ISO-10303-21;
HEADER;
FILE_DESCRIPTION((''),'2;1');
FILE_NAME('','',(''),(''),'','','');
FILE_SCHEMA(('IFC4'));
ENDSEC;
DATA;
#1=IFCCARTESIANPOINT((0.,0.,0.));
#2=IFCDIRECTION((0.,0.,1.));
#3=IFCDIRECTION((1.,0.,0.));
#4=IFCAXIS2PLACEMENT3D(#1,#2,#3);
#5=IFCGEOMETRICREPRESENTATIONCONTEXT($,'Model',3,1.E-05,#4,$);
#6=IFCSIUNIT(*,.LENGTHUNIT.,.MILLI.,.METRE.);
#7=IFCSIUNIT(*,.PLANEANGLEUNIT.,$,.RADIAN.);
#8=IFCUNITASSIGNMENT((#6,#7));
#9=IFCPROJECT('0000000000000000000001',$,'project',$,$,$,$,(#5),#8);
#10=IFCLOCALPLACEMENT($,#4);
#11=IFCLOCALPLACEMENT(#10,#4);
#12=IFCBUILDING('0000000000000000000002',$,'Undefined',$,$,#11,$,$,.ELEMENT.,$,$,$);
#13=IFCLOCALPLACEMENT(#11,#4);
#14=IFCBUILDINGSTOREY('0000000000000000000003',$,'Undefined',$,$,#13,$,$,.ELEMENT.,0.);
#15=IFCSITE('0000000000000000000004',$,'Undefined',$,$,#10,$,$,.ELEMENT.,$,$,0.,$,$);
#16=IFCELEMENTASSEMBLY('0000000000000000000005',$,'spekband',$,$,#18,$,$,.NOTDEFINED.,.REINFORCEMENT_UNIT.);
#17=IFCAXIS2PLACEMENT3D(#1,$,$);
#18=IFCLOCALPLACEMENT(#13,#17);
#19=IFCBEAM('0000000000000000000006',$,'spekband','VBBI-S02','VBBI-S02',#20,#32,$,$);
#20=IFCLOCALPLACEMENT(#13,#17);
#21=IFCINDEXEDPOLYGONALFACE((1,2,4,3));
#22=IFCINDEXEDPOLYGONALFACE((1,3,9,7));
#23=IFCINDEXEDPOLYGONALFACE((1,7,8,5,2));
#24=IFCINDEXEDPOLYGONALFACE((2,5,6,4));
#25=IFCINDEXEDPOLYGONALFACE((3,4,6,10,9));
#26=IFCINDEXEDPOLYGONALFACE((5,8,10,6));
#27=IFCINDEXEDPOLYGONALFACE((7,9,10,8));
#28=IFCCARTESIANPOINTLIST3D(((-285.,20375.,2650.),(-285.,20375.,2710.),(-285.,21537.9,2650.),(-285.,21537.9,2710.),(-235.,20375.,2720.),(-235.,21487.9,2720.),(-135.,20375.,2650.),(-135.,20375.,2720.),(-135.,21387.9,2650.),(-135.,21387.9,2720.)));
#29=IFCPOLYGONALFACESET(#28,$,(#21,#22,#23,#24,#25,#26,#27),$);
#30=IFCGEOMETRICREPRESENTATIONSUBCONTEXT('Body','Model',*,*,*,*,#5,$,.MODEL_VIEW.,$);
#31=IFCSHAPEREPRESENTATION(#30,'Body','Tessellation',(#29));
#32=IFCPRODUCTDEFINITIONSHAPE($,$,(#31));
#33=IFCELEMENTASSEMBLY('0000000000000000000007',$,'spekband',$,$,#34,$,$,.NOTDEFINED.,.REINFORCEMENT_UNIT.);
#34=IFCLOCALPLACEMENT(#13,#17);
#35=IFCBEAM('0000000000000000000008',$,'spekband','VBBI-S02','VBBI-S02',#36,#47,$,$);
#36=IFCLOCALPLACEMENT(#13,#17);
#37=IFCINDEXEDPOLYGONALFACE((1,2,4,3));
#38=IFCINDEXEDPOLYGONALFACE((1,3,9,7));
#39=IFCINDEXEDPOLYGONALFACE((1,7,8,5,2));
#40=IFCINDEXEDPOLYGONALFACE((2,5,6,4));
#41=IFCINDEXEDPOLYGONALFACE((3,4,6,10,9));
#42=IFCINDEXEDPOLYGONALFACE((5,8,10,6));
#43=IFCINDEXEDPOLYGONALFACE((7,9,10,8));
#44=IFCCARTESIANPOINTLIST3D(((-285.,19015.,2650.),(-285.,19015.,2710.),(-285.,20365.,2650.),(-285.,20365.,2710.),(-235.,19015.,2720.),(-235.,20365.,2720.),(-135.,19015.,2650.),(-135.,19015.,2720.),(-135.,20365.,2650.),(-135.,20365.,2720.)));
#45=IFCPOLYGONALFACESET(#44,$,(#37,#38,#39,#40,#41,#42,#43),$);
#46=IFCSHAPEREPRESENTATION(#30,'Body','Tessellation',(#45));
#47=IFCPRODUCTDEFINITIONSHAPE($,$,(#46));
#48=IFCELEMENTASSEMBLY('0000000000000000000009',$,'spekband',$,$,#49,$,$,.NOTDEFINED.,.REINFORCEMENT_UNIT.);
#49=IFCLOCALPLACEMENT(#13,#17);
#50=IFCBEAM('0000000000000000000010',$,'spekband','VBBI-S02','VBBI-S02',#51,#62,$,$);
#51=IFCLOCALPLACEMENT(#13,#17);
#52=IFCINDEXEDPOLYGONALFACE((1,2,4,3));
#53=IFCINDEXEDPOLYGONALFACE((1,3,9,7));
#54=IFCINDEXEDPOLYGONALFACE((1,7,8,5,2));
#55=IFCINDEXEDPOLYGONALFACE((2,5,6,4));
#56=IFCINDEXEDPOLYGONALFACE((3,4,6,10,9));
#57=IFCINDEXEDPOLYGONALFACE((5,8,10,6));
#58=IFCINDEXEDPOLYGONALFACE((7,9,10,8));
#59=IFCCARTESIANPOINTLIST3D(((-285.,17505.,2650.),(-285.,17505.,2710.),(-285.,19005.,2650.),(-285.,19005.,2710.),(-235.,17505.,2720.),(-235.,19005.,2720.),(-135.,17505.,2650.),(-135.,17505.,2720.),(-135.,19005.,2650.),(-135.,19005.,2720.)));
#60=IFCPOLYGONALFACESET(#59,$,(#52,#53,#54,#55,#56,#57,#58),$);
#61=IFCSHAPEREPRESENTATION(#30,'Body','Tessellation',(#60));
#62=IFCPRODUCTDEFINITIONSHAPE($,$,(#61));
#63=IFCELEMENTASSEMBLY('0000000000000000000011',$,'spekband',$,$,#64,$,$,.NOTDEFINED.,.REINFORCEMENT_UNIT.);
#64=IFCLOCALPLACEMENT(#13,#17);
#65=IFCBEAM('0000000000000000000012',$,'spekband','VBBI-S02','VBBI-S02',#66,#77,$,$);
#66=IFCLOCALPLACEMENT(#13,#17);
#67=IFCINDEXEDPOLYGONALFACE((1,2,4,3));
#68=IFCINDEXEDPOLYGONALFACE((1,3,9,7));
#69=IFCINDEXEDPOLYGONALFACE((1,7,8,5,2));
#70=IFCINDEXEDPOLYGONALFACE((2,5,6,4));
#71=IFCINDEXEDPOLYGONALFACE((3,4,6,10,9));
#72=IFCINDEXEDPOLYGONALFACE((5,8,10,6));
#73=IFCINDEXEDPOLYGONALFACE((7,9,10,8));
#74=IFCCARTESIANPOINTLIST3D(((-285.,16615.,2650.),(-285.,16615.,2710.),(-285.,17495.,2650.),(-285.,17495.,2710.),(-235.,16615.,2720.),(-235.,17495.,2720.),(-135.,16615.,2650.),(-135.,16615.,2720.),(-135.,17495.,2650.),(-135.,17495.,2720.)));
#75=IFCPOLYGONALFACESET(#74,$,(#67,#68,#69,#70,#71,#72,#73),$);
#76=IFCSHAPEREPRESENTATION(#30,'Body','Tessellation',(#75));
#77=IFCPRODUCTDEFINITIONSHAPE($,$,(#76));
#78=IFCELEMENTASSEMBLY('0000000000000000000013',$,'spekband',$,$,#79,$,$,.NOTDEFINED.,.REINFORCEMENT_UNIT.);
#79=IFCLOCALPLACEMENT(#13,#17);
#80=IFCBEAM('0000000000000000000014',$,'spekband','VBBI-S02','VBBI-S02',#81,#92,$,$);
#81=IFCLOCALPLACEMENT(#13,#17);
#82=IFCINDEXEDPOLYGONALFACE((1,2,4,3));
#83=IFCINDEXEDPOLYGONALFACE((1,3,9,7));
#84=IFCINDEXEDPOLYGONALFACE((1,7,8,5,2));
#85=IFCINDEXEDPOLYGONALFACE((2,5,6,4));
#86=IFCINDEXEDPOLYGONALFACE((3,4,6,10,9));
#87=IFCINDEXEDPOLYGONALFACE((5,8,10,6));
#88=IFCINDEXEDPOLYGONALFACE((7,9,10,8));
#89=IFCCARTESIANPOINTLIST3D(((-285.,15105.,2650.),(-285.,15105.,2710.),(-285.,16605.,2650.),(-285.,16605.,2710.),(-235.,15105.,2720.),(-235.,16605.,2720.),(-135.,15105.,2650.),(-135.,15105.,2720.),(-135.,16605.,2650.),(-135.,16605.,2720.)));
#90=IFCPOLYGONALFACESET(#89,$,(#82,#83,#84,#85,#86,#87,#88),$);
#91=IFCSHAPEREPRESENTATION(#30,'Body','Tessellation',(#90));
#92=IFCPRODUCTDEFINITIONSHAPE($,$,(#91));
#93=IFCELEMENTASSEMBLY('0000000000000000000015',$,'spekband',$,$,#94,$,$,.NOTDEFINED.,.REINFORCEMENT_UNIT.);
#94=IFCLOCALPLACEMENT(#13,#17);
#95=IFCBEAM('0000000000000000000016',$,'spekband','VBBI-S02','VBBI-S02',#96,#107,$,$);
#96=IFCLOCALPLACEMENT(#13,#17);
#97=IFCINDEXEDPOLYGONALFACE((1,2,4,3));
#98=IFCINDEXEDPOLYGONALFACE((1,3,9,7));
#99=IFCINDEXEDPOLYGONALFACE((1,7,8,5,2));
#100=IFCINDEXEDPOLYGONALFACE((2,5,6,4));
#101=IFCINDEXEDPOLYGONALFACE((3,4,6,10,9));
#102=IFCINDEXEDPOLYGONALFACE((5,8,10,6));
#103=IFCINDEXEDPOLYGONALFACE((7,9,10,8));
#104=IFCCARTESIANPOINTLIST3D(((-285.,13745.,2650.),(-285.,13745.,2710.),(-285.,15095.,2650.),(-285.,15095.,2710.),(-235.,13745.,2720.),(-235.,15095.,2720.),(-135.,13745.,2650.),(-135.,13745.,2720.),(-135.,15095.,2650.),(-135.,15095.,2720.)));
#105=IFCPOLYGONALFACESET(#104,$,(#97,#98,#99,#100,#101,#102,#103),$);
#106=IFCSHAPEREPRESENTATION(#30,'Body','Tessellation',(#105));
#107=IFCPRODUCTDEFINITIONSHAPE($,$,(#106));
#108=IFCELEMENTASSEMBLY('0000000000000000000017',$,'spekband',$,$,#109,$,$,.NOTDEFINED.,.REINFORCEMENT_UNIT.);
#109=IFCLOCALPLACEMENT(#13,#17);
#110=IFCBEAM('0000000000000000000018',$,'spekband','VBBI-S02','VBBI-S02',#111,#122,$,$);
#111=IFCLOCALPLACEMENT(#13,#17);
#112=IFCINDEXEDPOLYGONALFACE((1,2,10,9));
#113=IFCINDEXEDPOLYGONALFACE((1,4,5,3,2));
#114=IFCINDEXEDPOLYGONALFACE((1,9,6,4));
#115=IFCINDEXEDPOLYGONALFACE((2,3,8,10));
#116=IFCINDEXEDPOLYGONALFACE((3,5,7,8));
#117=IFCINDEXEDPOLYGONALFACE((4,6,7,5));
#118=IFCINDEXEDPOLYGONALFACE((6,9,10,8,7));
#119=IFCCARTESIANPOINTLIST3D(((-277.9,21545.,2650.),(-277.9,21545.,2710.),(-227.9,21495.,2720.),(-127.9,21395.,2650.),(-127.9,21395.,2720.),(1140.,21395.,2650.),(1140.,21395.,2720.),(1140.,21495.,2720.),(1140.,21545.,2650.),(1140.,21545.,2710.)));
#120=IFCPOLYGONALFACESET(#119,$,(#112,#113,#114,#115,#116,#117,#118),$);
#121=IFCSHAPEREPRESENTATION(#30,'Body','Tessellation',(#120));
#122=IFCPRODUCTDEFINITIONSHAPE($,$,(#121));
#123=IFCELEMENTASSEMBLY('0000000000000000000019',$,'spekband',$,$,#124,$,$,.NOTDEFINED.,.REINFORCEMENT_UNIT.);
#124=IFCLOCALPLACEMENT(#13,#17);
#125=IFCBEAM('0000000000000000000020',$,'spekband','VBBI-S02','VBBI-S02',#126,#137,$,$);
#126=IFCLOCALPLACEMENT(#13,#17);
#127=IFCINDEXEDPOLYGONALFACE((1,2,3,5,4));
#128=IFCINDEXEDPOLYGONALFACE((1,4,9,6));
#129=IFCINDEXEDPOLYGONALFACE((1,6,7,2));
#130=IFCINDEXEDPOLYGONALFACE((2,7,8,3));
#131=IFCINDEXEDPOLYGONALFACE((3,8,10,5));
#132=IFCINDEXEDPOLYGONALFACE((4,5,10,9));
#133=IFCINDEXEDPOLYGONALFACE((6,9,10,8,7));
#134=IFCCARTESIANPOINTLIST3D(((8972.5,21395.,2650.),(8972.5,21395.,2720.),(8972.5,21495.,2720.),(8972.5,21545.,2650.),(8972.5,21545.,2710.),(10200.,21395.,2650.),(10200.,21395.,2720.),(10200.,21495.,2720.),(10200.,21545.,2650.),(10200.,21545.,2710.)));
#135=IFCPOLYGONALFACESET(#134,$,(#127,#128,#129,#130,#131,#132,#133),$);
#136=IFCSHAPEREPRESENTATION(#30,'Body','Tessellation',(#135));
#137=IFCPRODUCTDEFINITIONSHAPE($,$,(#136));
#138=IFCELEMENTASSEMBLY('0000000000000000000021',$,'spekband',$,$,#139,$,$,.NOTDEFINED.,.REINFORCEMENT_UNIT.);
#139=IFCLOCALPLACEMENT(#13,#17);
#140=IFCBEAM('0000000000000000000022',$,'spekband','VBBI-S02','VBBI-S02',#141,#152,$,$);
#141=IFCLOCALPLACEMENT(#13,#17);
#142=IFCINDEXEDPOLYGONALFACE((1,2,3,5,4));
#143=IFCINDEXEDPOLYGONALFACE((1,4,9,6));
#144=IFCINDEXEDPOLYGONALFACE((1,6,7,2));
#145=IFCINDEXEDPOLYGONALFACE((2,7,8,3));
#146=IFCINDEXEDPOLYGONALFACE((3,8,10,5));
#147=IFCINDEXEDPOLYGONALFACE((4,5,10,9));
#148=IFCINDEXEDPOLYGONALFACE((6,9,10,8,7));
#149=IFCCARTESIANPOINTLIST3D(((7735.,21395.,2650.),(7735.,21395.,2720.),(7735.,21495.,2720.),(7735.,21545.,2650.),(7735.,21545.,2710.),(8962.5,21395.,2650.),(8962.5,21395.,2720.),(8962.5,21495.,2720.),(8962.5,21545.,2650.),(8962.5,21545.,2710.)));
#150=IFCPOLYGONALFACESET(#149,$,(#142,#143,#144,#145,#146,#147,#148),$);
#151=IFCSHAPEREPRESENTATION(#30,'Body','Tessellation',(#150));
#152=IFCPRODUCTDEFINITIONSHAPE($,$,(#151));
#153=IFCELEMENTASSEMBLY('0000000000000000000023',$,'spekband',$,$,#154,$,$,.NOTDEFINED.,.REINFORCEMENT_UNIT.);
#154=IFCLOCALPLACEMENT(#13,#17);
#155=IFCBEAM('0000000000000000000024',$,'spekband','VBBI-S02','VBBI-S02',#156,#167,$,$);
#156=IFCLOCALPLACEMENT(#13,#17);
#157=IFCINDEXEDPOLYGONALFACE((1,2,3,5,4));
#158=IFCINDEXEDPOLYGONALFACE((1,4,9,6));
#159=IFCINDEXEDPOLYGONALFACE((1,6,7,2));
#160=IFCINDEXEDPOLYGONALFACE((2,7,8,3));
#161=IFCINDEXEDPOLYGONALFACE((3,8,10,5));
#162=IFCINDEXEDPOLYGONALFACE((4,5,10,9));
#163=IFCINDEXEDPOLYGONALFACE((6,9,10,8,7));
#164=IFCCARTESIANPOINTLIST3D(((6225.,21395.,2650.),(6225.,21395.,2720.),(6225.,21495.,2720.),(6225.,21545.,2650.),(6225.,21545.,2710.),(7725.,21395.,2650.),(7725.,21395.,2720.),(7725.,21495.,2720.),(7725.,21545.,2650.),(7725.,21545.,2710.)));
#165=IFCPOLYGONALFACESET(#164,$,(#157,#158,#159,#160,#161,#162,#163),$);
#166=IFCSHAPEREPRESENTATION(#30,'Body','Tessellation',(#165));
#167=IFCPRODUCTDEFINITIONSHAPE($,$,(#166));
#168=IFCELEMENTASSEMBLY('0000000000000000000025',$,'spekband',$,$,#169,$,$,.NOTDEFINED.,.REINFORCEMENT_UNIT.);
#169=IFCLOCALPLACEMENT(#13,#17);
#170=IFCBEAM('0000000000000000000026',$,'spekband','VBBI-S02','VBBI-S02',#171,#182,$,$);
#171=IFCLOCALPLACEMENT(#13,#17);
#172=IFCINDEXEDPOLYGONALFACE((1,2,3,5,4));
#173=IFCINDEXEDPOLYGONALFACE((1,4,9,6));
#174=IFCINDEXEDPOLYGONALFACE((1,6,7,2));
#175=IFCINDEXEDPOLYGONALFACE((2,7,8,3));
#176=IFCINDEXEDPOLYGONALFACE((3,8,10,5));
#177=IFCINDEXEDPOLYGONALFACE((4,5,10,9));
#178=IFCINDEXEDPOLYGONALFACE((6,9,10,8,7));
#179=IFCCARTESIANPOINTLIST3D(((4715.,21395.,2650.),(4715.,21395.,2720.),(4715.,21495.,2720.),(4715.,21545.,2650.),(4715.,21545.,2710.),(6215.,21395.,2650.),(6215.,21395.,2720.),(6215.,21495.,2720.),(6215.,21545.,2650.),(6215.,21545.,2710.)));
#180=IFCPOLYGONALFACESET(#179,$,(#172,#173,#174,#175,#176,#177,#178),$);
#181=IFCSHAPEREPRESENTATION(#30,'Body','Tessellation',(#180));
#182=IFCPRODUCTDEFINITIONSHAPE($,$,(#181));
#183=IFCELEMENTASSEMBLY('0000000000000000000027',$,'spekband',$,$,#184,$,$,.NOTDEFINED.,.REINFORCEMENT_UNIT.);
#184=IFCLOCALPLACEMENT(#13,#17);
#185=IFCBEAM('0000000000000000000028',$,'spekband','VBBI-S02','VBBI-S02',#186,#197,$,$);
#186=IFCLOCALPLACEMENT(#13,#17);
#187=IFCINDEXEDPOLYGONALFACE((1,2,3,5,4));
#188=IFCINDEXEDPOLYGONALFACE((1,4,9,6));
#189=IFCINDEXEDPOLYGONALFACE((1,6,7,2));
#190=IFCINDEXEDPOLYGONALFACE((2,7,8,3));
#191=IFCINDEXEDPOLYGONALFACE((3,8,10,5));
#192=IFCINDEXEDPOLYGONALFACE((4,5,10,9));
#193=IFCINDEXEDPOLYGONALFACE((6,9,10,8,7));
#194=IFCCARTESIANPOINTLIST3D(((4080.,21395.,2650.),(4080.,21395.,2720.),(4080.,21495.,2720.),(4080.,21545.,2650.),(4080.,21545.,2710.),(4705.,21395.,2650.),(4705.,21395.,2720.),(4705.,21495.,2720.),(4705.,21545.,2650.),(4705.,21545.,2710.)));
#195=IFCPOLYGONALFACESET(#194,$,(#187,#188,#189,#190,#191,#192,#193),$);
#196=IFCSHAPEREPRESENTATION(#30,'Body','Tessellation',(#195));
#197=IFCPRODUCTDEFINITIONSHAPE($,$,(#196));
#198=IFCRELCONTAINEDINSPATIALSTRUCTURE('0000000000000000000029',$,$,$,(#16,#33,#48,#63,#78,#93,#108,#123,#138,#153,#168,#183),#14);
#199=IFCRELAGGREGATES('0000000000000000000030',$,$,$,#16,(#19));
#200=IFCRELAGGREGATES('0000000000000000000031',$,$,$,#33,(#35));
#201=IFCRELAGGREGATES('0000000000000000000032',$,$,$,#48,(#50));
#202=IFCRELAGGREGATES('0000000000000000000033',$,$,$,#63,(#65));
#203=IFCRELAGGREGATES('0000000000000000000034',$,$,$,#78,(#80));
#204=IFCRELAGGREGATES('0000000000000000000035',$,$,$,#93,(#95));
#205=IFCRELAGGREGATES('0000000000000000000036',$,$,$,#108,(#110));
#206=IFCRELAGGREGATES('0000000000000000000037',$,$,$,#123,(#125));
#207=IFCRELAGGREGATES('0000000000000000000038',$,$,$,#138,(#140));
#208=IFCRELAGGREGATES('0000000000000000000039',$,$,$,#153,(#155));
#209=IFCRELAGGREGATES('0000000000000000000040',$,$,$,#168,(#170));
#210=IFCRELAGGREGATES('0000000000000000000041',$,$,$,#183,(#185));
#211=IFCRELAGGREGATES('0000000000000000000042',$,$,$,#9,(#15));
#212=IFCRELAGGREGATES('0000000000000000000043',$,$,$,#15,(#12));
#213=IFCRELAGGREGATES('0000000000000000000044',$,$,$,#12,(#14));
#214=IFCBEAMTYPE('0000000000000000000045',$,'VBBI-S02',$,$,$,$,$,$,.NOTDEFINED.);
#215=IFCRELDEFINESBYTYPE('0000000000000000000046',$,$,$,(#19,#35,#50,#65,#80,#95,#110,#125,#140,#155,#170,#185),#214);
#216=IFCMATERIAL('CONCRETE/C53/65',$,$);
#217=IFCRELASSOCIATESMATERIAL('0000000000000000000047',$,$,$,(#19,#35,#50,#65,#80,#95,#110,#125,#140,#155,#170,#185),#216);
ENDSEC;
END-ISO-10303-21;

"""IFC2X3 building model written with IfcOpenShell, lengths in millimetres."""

from ifc_helpers import new_model, si_unit, frame, origin_with_axes, place, context, subcontext, project, spatial, polyline, outline, extrude, clip, halfspace, material, type_object, element, aggregate, save


model = new_model("IFC2X3")

# Units and contexts
model_context = context("Model", 3, precision=1e-05, world=origin_with_axes())
body_context = subcontext(model_context, "Body", "Model", "MODEL_VIEW")
ifc_project = project(units=[si_unit("LENGTHUNIT", "METRE", prefix="MILLI"), si_unit("PLANEANGLEUNIT", "RADIAN")], contexts=[model_context])

# Site, building, storey
site_placement = place(None, origin_with_axes())
site = spatial("IfcSite", under=ifc_project, at=site_placement, Name="Undefined", CompositionType="ELEMENT", RefElevation=0.0)
building_placement = place(site_placement, origin_with_axes())
building = spatial("IfcBuilding", under=site, at=building_placement, Name="Undefined", CompositionType="ELEMENT")
storey_placement = place(building_placement, origin_with_axes())
storey = spatial("IfcBuildingStorey", under=building, at=storey_placement, Name="Undefined", CompositionType="ELEMENT", Elevation=0.0)

# Element assemblies, beams
assembly_1_placement = place(storey_placement, origin_with_axes())
assembly_1 = element("IfcElementAssembly", 1, at=assembly_1_placement, inside=storey, Name="spekband", AssemblyPlace="NOTDEFINED", PredefinedType="REINFORCEMENT_UNIT")
ifc_material_1 = material(Name="CONCRETE/C53/65")
beam_type = type_object("IfcBeamType", Name="VBBI-S02", PredefinedType="NOTDEFINED")
beam_1_placement = place(assembly_1_placement, frame((-210.0, 21545.0, 2685.0), z_axis=(-1.0, 0.0, 0.0), x_axis=(0.0, -1.0, 0.0)))
beam_1 = element("IfcBeam", 2, at=beam_1_placement, type_object=beam_type, material=ifc_material_1, Name="spekband", Description="VBBI-S02", ObjectType="VBBI-S02", context=body_context, shape_type="Clipping", body=[
    clip(extrude(outline(polyline([(35.0, -75.0), (-35.0, -75.0), (-35.0, 25.0), (-25.0, 75.0), (35.0, 75.0), (35.0, -75.0)])), frame((1170.0, 0.0, 0.0), z_axis=(-1.0, 0.0, 0.0), x_axis=(0.0, -1.0, 0.0)), (0.0, 0.0, 1.0), 1163.7), halfspace(frame((3.5, 0.0, 78.5), z_axis=(0.707107, 0.0, 0.707107), x_axis=(0.0, 1.0, 0.0)), True)),
])
aggregate(assembly_1, [beam_1])
assembly_2_placement = place(storey_placement, origin_with_axes())
assembly_2 = element("IfcElementAssembly", 3, at=assembly_2_placement, inside=storey, Name="spekband", AssemblyPlace="NOTDEFINED", PredefinedType="REINFORCEMENT_UNIT")
beam_2_placement = place(assembly_2_placement, frame((-210.0, 20365.0, 2685.0), z_axis=(-1.0, 0.0, 0.0), x_axis=(0.0, -1.0, 0.0)))
beam_2 = element("IfcBeam", 4, at=beam_2_placement, type_object=beam_type, material=ifc_material_1, Name="spekband", Description="VBBI-S02", ObjectType="VBBI-S02", context=body_context, shape_type="SweptSolid", body=[
    extrude(outline(polyline([(35.0, -75.0), (-35.0, -75.0), (-35.0, 25.0), (-25.0, 75.0), (35.0, 75.0), (35.0, -75.0)])), frame((1350.0, 0.0, 0.0), z_axis=(-1.0, 0.0, 0.0), x_axis=(0.0, -1.0, 0.0)), (0.0, 0.0, 1.0), 1350.0),
])
aggregate(assembly_2, [beam_2])
assembly_3_placement = place(storey_placement, origin_with_axes())
assembly_3 = element("IfcElementAssembly", 5, at=assembly_3_placement, inside=storey, Name="spekband", AssemblyPlace="NOTDEFINED", PredefinedType="REINFORCEMENT_UNIT")
beam_3_placement = place(assembly_3_placement, frame((-210.0, 19005.0, 2685.0), z_axis=(-1.0, 0.0, 0.0), x_axis=(0.0, -1.0, 0.0)))
beam_3 = element("IfcBeam", 6, at=beam_3_placement, type_object=beam_type, material=ifc_material_1, Name="spekband", Description="VBBI-S02", ObjectType="VBBI-S02", context=body_context, shape_type="SweptSolid", body=[
    extrude(outline(polyline([(35.0, -75.0), (-35.0, -75.0), (-35.0, 25.0), (-25.0, 75.0), (35.0, 75.0), (35.0, -75.0)])), frame((1500.0, 0.0, 0.0), z_axis=(-1.0, 0.0, 0.0), x_axis=(0.0, -1.0, 0.0)), (0.0, 0.0, 1.0), 1500.0),
])
aggregate(assembly_3, [beam_3])
assembly_4_placement = place(storey_placement, origin_with_axes())
assembly_4 = element("IfcElementAssembly", 7, at=assembly_4_placement, inside=storey, Name="spekband", AssemblyPlace="NOTDEFINED", PredefinedType="REINFORCEMENT_UNIT")
beam_4_placement = place(assembly_4_placement, frame((-210.0, 17495.0, 2685.0), z_axis=(-1.0, 0.0, 0.0), x_axis=(0.0, -1.0, 0.0)))
beam_4 = element("IfcBeam", 8, at=beam_4_placement, type_object=beam_type, material=ifc_material_1, Name="spekband", Description="VBBI-S02", ObjectType="VBBI-S02", context=body_context, shape_type="SweptSolid", body=[
    extrude(outline(polyline([(35.0, -75.0), (-35.0, -75.0), (-35.0, 25.0), (-25.0, 75.0), (35.0, 75.0), (35.0, -75.0)])), frame((880.0, 0.0, 0.0), z_axis=(-1.0, 0.0, 0.0), x_axis=(0.0, -1.0, 0.0)), (0.0, 0.0, 1.0), 880.0),
])
aggregate(assembly_4, [beam_4])
assembly_5_placement = place(storey_placement, origin_with_axes())
assembly_5 = element("IfcElementAssembly", 9, at=assembly_5_placement, inside=storey, Name="spekband", AssemblyPlace="NOTDEFINED", PredefinedType="REINFORCEMENT_UNIT")
beam_5_placement = place(assembly_5_placement, frame((-210.0, 16605.0, 2685.0), z_axis=(-1.0, 0.0, 0.0), x_axis=(0.0, -1.0, 0.0)))
beam_5 = element("IfcBeam", 10, at=beam_5_placement, type_object=beam_type, material=ifc_material_1, Name="spekband", Description="VBBI-S02", ObjectType="VBBI-S02", context=body_context, shape_type="SweptSolid", body=[
    extrude(outline(polyline([(35.0, -75.0), (-35.0, -75.0), (-35.0, 25.0), (-25.0, 75.0), (35.0, 75.0), (35.0, -75.0)])), frame((1500.0, 0.0, 0.0), z_axis=(-1.0, 0.0, 0.0), x_axis=(0.0, -1.0, 0.0)), (0.0, 0.0, 1.0), 1500.0),
])
aggregate(assembly_5, [beam_5])
assembly_6_placement = place(storey_placement, origin_with_axes())
assembly_6 = element("IfcElementAssembly", 11, at=assembly_6_placement, inside=storey, Name="spekband", AssemblyPlace="NOTDEFINED", PredefinedType="REINFORCEMENT_UNIT")
beam_6_placement = place(assembly_6_placement, frame((-210.0, 15095.0, 2685.0), z_axis=(-1.0, 0.0, 0.0), x_axis=(0.0, -1.0, 0.0)))
beam_6 = element("IfcBeam", 12, at=beam_6_placement, type_object=beam_type, material=ifc_material_1, Name="spekband", Description="VBBI-S02", ObjectType="VBBI-S02", context=body_context, shape_type="SweptSolid", body=[
    extrude(outline(polyline([(35.0, -75.0), (-35.0, -75.0), (-35.0, 25.0), (-25.0, 75.0), (35.0, 75.0), (35.0, -75.0)])), frame((1350.0, 0.0, 0.0), z_axis=(-1.0, 0.0, 0.0), x_axis=(0.0, -1.0, 0.0)), (0.0, 0.0, 1.0), 1350.0),
])
aggregate(assembly_6, [beam_6])
assembly_7_placement = place(storey_placement, origin_with_axes())
assembly_7 = element("IfcElementAssembly", 13, at=assembly_7_placement, inside=storey, Name="spekband", AssemblyPlace="NOTDEFINED", PredefinedType="REINFORCEMENT_UNIT")
beam_7_placement = place(assembly_7_placement, frame((1140.0, 21470.0, 2685.0), z_axis=(0.0, 1.0, 0.0), x_axis=(-1.0, 0.0, 0.0)))
beam_7 = element("IfcBeam", 14, at=beam_7_placement, type_object=beam_type, material=ifc_material_1, Name="spekband", Description="VBBI-S02", ObjectType="VBBI-S02", context=body_context, shape_type="Clipping", body=[
    clip(extrude(outline(polyline([(35.0, -75.0), (-35.0, -75.0), (-35.0, 25.0), (-25.0, 75.0), (35.0, 75.0), (35.0, -75.0)])), frame((1418.7, 0.0, 0.0), z_axis=(-1.0, 0.0, 0.0), x_axis=(0.0, -1.0, 0.0)), (0.0, 0.0, 1.0), 1418.7), halfspace(frame((1421.5, 0.0, 78.5), z_axis=(0.707107, 0.0, -0.707107), x_axis=(0.0, 1.0, 0.0)), False)),
])
aggregate(assembly_7, [beam_7])
assembly_8_placement = place(storey_placement, origin_with_axes())
assembly_8 = element("IfcElementAssembly", 15, at=assembly_8_placement, inside=storey, Name="spekband", AssemblyPlace="NOTDEFINED", PredefinedType="REINFORCEMENT_UNIT")
beam_8_placement = place(assembly_8_placement, frame((10200.0, 21470.0, 2685.0), z_axis=(0.0, 1.0, 0.0), x_axis=(-1.0, 0.0, 0.0)))
beam_8 = element("IfcBeam", 16, at=beam_8_placement, type_object=beam_type, material=ifc_material_1, Name="spekband", Description="VBBI-S02", ObjectType="VBBI-S02", context=body_context, shape_type="SweptSolid", body=[
    extrude(outline(polyline([(35.0, -75.0), (-35.0, -75.0), (-35.0, 25.0), (-25.0, 75.0), (35.0, 75.0), (35.0, -75.0)])), frame((1227.5, 0.0, 0.0), z_axis=(-1.0, 0.0, 0.0), x_axis=(0.0, -1.0, 0.0)), (0.0, 0.0, 1.0), 1227.5),
])
aggregate(assembly_8, [beam_8])
assembly_9_placement = place(storey_placement, origin_with_axes())
assembly_9 = element("IfcElementAssembly", 17, at=assembly_9_placement, inside=storey, Name="spekband", AssemblyPlace="NOTDEFINED", PredefinedType="REINFORCEMENT_UNIT")
beam_9_placement = place(assembly_9_placement, frame((8962.5, 21470.0, 2685.0), z_axis=(0.0, 1.0, 0.0), x_axis=(-1.0, 0.0, 0.0)))
beam_9 = element("IfcBeam", 18, at=beam_9_placement, type_object=beam_type, material=ifc_material_1, Name="spekband", Description="VBBI-S02", ObjectType="VBBI-S02", context=body_context, shape_type="SweptSolid", body=[
    extrude(outline(polyline([(35.0, -75.0), (-35.0, -75.0), (-35.0, 25.0), (-25.0, 75.0), (35.0, 75.0), (35.0, -75.0)])), frame((1227.5, 0.0, 0.0), z_axis=(-1.0, 0.0, 0.0), x_axis=(0.0, -1.0, 0.0)), (0.0, 0.0, 1.0), 1227.5),
])
aggregate(assembly_9, [beam_9])
assembly_10_placement = place(storey_placement, origin_with_axes())
assembly_10 = element("IfcElementAssembly", 19, at=assembly_10_placement, inside=storey, Name="spekband", AssemblyPlace="NOTDEFINED", PredefinedType="REINFORCEMENT_UNIT")
beam_10_placement = place(assembly_10_placement, frame((7725.0, 21470.0, 2685.0), z_axis=(0.0, 1.0, 0.0), x_axis=(-1.0, 0.0, 0.0)))
beam_10 = element("IfcBeam", 20, at=beam_10_placement, type_object=beam_type, material=ifc_material_1, Name="spekband", Description="VBBI-S02", ObjectType="VBBI-S02", context=body_context, shape_type="SweptSolid", body=[
    extrude(outline(polyline([(35.0, -75.0), (-35.0, -75.0), (-35.0, 25.0), (-25.0, 75.0), (35.0, 75.0), (35.0, -75.0)])), frame((1500.0, 0.0, 0.0), z_axis=(-1.0, 0.0, 0.0), x_axis=(0.0, -1.0, 0.0)), (0.0, 0.0, 1.0), 1500.0),
])
aggregate(assembly_10, [beam_10])
assembly_11_placement = place(storey_placement, origin_with_axes())
assembly_11 = element("IfcElementAssembly", 21, at=assembly_11_placement, inside=storey, Name="spekband", AssemblyPlace="NOTDEFINED", PredefinedType="REINFORCEMENT_UNIT")
beam_11_placement = place(assembly_11_placement, frame((6215.0, 21470.0, 2685.0), z_axis=(0.0, 1.0, 0.0), x_axis=(-1.0, 0.0, 0.0)))
beam_11 = element("IfcBeam", 22, at=beam_11_placement, type_object=beam_type, material=ifc_material_1, Name="spekband", Description="VBBI-S02", ObjectType="VBBI-S02", context=body_context, shape_type="SweptSolid", body=[
    extrude(outline(polyline([(35.0, -75.0), (-35.0, -75.0), (-35.0, 25.0), (-25.0, 75.0), (35.0, 75.0), (35.0, -75.0)])), frame((1500.0, 0.0, 0.0), z_axis=(-1.0, 0.0, 0.0), x_axis=(0.0, -1.0, 0.0)), (0.0, 0.0, 1.0), 1500.0),
])
aggregate(assembly_11, [beam_11])
assembly_12_placement = place(storey_placement, origin_with_axes())
assembly_12 = element("IfcElementAssembly", 23, at=assembly_12_placement, inside=storey, Name="spekband", AssemblyPlace="NOTDEFINED", PredefinedType="REINFORCEMENT_UNIT")
beam_12_placement = place(assembly_12_placement, frame((4705.0, 21470.0, 2685.0), z_axis=(0.0, 1.0, 0.0), x_axis=(-1.0, 0.0, 0.0)))
beam_12 = element("IfcBeam", 24, at=beam_12_placement, type_object=beam_type, material=ifc_material_1, Name="spekband", Description="VBBI-S02", ObjectType="VBBI-S02", context=body_context, shape_type="SweptSolid", body=[
    extrude(outline(polyline([(35.0, -75.0), (-35.0, -75.0), (-35.0, 25.0), (-25.0, 75.0), (35.0, 75.0), (35.0, -75.0)])), frame((625.0, 0.0, 0.0), z_axis=(-1.0, 0.0, 0.0), x_axis=(0.0, -1.0, 0.0)), (0.0, 0.0, 1.0), 625.0),
])
aggregate(assembly_12, [beam_12])

save(model, "model.ifc")
